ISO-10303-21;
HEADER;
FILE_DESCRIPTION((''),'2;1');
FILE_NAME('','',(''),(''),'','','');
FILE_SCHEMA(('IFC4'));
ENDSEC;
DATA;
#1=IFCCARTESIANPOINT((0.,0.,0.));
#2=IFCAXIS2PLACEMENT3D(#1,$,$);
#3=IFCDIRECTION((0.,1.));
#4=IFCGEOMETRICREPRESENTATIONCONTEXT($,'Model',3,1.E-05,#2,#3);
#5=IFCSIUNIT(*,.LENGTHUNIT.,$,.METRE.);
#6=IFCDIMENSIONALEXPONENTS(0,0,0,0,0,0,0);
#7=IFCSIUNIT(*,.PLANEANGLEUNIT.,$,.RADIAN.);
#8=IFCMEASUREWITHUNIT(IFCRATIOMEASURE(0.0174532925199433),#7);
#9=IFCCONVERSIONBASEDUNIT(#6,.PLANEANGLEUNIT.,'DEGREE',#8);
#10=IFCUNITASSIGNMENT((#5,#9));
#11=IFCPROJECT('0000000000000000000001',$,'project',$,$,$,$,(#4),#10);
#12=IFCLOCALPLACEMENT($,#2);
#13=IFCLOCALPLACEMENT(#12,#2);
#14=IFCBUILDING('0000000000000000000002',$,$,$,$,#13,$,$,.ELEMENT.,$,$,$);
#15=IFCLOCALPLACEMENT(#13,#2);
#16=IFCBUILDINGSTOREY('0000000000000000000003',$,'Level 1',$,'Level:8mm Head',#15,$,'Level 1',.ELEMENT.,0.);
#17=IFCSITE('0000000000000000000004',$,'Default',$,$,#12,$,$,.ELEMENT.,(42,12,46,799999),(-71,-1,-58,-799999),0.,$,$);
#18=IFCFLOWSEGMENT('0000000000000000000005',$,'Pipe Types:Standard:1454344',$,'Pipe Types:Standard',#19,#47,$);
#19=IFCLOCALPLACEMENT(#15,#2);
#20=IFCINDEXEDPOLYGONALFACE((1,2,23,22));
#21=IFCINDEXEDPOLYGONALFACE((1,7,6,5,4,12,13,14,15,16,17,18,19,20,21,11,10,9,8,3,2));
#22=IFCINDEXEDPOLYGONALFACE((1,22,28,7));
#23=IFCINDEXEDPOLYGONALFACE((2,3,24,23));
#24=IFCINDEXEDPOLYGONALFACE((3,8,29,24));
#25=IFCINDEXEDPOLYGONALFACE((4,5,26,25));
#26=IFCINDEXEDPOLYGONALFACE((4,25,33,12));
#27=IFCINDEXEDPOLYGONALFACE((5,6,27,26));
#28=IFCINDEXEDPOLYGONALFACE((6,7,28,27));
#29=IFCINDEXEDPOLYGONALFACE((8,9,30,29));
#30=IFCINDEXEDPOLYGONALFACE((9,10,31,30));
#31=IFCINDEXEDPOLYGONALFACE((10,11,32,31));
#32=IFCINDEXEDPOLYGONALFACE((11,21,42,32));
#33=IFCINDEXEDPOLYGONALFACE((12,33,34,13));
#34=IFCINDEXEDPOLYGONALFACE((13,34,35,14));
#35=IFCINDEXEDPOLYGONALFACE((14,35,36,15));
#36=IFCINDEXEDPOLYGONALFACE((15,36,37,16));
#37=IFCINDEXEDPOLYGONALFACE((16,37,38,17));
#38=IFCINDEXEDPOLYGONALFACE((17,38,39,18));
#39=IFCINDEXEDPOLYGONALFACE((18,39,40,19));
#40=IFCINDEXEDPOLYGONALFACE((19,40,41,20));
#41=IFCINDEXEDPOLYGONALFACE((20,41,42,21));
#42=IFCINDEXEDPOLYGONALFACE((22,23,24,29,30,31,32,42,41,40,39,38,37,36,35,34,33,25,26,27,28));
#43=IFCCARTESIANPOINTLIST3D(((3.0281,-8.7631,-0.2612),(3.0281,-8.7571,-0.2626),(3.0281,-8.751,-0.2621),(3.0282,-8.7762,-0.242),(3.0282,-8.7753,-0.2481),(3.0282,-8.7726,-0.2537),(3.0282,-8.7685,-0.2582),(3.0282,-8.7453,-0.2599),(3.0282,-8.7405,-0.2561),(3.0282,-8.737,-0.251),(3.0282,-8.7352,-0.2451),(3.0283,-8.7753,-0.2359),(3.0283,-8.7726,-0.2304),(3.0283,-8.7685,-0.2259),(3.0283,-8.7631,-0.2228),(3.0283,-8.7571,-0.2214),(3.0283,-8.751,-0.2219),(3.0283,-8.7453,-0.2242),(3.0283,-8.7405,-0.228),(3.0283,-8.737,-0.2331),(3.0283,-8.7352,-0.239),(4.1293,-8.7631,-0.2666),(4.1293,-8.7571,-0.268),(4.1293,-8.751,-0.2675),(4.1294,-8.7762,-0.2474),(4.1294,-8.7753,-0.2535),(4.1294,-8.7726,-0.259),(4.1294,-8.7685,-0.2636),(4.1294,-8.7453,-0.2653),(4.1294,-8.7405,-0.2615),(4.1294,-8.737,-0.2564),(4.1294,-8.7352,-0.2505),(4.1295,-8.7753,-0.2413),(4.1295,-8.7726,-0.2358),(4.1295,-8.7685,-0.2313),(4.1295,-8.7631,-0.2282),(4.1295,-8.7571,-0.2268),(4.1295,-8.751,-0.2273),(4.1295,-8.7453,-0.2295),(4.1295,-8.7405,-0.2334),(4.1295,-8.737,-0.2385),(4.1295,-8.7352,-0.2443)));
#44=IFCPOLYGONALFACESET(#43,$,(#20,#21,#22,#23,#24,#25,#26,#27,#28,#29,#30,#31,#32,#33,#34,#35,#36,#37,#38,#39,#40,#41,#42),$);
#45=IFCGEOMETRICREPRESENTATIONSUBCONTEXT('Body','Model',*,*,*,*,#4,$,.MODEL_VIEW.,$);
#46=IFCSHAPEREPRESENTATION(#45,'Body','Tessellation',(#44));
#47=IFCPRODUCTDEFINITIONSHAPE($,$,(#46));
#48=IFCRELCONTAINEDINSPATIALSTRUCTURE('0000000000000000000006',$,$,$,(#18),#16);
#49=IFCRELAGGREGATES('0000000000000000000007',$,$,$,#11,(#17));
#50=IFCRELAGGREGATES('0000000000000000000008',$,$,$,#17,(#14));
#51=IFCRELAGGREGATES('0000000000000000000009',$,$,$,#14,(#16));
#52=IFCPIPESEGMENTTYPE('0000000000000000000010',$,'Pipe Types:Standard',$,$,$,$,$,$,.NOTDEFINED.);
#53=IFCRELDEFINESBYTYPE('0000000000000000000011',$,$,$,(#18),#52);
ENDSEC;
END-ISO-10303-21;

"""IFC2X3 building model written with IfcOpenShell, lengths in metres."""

from ifc_helpers import new_model, entity, si_unit, converted_unit, direction, frame, origin, origin_2d_with_axis, place, context, subcontext, project, spatial, circle, extrude, type_object, element, save


model = new_model("IFC2X3")

# Units and contexts
model_context = context("Model", 3, precision=1e-05, world=origin(), true_north=direction((0.0, 1.0)))
body_context = subcontext(model_context, "Body", "Model", "MODEL_VIEW")
ifc_project = project(units=[si_unit("LENGTHUNIT", "METRE"), converted_unit("PLANEANGLEUNIT", "DEGREE", entity("IfcRatioMeasure", 0.0174532925199433), si_unit("PLANEANGLEUNIT", "RADIAN"), dimensions=[0, 0, 0, 0, 0, 0, 0])], contexts=[model_context])

# Site, building, storey
site_placement = place(None, origin())
site = spatial("IfcSite", under=ifc_project, at=site_placement, Name="Default", CompositionType="ELEMENT", RefLatitude=(42, 12, 46, 799999), RefLongitude=(-71, -1, -58, -799999), RefElevation=0.0)
building_placement = place(site_placement, origin())
building = spatial("IfcBuilding", under=site, at=building_placement, CompositionType="ELEMENT")
storey_placement = place(building_placement, origin())
storey = spatial("IfcBuildingStorey", under=building, at=storey_placement, Name="Level 1", ObjectType="Level:8mm Head", LongName="Level 1", CompositionType="ELEMENT", Elevation=0.0)

# Flow segment
pipe_segment_type = type_object("IfcPipeSegmentType", Name="Pipe Types:Standard", PredefinedType="NOTDEFINED")
flow_segment_1_placement = place(storey_placement, origin())
element("IfcFlowSegment", 1, at=flow_segment_1_placement, inside=storey, type_object=pipe_segment_type, Name="Pipe Types:Standard:1454344", ObjectType="Pipe Types:Standard", context=body_context, shape_type="SweptSolid", body=[
    extrude(circle(Radius=0.0206, at=origin_2d_with_axis()), frame((4.1294, -8.7556, -0.2474), z_axis=(-0.999988, 0.0, 0.004897), x_axis=(0.0, -1.0, 0.0)), (0.0, 0.0, 1.0), 1.1012),
])

save(model, "model.ifc")
